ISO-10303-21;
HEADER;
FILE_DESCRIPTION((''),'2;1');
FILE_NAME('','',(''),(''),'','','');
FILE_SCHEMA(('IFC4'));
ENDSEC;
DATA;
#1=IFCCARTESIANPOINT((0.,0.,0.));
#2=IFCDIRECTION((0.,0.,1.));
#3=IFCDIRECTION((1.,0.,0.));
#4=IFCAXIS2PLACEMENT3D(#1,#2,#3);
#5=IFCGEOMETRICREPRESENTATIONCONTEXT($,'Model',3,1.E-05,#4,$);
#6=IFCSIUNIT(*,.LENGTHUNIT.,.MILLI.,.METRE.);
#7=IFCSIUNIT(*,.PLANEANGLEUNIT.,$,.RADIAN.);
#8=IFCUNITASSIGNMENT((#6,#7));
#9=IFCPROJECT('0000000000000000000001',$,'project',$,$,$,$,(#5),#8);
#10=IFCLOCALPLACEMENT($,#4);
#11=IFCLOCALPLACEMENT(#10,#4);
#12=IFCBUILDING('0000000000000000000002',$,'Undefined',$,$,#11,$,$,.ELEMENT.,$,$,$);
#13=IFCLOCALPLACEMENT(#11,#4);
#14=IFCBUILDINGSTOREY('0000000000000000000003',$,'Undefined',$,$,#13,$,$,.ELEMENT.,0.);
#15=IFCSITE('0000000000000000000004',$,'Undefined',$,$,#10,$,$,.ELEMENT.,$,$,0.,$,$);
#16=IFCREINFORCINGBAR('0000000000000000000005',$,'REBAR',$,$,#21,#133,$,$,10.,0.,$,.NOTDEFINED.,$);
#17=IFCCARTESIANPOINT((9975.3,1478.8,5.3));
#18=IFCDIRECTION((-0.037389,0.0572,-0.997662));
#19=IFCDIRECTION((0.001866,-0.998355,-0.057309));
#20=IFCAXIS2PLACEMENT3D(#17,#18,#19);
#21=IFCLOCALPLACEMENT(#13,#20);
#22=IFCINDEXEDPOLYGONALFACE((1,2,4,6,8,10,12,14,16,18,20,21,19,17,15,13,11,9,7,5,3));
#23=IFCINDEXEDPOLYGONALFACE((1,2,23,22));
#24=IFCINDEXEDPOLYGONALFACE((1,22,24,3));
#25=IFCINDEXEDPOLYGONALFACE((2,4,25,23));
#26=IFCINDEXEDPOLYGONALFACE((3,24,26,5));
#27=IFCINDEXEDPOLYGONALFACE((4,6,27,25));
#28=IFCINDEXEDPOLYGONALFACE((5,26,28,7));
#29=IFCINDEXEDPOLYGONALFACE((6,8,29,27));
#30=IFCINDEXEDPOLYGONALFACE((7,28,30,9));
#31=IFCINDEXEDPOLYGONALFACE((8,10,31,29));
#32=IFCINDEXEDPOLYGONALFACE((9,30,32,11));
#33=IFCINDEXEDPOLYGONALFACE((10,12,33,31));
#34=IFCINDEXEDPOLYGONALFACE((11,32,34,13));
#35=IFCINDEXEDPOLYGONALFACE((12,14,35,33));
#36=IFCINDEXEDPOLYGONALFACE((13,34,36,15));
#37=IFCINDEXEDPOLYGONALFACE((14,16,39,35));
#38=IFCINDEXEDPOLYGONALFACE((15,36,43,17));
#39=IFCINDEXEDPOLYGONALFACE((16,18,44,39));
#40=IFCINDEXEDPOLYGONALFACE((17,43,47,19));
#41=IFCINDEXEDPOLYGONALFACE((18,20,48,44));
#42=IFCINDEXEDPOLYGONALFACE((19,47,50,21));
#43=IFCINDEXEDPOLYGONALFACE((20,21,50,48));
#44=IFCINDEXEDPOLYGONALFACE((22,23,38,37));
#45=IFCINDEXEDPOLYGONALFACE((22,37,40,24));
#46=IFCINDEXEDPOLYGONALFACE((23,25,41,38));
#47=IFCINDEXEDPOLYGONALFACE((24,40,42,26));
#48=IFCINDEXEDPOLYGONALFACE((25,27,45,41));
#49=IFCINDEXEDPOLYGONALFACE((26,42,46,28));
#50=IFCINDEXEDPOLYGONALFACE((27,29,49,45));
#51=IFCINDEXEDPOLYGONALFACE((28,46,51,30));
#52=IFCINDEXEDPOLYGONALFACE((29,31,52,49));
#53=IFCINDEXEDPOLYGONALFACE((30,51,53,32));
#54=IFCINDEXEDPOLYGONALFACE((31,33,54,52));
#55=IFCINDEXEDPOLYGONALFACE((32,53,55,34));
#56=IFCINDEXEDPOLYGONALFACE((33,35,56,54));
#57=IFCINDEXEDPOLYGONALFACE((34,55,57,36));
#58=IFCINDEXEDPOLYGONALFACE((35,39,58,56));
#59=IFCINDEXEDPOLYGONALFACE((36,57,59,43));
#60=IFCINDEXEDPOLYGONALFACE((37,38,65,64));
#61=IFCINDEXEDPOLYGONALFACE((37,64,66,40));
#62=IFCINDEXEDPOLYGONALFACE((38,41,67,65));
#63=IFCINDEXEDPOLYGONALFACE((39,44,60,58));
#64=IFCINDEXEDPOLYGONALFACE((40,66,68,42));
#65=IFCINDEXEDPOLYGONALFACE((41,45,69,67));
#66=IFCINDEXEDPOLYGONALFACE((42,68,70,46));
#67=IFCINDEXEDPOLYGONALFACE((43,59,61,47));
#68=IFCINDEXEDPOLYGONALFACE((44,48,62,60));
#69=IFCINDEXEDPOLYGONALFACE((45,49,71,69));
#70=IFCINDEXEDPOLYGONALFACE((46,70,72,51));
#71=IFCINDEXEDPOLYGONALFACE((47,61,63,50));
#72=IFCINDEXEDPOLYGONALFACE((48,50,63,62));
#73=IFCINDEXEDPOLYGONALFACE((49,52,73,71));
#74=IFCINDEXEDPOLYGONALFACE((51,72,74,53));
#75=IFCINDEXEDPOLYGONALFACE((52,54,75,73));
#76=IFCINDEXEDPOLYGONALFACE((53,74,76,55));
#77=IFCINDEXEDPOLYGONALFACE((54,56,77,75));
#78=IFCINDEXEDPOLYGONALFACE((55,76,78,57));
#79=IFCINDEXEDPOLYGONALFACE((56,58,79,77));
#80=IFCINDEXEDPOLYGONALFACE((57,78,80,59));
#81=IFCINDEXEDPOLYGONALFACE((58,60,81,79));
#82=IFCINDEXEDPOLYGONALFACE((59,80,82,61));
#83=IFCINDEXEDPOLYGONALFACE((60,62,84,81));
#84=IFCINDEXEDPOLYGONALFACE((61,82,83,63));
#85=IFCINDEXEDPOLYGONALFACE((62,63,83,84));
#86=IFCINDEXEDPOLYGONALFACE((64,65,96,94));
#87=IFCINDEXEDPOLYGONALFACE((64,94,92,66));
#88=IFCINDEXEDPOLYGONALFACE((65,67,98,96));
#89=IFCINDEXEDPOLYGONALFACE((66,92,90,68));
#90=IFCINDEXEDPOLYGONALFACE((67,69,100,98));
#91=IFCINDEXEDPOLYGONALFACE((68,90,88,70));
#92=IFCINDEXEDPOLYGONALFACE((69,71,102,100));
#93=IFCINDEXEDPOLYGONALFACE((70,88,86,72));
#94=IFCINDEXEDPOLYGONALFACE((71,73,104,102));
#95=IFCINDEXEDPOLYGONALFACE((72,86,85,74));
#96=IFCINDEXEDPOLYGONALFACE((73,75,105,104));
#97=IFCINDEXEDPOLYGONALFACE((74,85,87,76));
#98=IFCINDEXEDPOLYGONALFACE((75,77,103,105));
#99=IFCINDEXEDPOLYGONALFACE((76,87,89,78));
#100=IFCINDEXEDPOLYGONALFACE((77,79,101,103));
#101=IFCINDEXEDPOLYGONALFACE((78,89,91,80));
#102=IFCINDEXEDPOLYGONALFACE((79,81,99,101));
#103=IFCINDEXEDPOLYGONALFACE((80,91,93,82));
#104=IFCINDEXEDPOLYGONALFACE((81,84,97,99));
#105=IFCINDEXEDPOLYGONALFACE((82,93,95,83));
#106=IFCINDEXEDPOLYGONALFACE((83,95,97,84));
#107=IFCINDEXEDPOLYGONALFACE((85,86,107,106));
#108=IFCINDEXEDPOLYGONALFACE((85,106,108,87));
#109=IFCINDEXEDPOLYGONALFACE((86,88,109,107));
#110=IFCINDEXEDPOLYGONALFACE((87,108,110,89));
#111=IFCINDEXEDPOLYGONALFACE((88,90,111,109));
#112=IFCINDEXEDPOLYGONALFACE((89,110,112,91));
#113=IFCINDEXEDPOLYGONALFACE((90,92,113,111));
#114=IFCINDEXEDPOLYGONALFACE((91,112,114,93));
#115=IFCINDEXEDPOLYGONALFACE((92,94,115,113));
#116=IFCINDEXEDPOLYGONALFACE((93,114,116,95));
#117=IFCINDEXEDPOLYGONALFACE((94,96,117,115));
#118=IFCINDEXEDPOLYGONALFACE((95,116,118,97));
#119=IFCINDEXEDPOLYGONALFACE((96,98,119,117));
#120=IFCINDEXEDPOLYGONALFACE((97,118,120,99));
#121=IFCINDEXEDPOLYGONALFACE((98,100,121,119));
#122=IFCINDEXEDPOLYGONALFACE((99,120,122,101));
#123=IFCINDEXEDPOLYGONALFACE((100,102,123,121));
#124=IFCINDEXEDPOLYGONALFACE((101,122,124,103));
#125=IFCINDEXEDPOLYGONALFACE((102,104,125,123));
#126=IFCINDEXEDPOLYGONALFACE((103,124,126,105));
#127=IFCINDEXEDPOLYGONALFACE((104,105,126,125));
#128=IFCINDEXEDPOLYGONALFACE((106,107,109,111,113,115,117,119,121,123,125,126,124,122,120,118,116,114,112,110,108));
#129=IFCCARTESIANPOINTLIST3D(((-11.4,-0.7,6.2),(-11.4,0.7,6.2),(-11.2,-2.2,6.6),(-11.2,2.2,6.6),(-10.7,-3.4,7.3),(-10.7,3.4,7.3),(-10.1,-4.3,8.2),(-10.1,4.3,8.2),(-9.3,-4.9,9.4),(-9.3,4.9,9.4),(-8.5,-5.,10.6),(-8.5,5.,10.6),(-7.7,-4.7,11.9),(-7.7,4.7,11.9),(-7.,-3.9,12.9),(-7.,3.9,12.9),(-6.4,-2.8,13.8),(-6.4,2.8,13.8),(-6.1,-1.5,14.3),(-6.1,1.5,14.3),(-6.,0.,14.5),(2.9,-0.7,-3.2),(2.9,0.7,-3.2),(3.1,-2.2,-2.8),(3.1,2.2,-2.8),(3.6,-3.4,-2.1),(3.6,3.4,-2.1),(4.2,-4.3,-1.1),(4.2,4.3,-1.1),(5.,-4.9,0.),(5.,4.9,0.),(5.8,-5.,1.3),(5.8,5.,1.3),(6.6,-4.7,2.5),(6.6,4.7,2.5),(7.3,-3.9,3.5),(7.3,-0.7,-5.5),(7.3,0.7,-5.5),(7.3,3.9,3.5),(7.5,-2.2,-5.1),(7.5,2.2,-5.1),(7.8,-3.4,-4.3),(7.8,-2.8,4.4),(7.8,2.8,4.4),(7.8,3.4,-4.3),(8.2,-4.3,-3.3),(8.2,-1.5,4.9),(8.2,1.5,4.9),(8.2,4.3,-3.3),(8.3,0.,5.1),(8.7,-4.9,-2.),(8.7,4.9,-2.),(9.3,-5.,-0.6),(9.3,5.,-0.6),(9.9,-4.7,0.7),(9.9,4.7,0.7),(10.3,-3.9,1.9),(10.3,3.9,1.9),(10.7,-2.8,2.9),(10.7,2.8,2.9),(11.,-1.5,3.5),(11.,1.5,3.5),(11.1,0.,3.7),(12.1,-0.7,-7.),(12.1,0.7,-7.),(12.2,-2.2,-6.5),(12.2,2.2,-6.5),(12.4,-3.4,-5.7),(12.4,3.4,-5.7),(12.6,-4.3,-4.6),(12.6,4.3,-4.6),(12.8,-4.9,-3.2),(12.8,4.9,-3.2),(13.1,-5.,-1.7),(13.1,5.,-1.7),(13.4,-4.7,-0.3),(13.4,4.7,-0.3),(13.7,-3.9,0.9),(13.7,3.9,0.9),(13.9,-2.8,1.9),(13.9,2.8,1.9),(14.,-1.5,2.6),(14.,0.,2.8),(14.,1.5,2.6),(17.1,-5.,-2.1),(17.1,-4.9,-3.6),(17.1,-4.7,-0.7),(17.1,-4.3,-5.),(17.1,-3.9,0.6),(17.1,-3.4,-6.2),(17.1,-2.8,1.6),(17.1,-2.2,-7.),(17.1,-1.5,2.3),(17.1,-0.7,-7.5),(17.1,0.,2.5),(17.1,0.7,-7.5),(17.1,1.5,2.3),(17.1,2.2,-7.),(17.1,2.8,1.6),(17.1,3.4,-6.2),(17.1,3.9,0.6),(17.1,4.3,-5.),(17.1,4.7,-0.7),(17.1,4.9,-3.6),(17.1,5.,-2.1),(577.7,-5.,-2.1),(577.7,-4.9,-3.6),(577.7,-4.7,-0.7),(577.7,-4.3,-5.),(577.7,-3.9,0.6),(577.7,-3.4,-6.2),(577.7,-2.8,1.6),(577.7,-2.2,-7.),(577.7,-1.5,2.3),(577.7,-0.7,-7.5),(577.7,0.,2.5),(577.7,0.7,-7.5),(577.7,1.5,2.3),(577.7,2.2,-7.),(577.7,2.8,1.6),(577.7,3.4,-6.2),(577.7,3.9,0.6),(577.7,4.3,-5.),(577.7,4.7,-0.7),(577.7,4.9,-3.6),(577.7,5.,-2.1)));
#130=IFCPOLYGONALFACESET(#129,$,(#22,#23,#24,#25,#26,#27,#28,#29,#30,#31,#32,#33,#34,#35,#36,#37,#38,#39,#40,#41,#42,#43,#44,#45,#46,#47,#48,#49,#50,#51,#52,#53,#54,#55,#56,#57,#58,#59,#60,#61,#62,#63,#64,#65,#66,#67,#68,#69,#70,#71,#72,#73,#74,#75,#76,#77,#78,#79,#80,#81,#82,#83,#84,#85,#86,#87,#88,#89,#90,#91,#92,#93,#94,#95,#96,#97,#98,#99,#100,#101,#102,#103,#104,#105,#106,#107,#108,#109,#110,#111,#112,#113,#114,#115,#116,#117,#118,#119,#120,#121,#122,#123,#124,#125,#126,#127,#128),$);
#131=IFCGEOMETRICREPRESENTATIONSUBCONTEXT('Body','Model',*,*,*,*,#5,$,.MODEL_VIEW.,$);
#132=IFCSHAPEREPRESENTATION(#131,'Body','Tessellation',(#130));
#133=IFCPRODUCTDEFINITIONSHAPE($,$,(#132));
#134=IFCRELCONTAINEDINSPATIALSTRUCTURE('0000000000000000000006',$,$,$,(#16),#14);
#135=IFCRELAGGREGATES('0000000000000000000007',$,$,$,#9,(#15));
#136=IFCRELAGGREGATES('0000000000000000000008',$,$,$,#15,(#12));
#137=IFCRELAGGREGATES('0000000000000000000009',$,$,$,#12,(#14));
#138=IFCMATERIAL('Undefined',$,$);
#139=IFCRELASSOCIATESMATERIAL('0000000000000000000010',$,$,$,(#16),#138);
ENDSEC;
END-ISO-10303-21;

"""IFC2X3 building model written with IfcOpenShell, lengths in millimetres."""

from ifc_helpers import new_model, entity, si_unit, frame, origin_with_axes, place, context, subcontext, project, spatial, source, transform, mapped, material, element, save


model = new_model("IFC2X3")

# Units and contexts
model_context = context("Model", 3, precision=1e-05, world=origin_with_axes())
body_context = subcontext(model_context, "Body", "Model", "MODEL_VIEW")
ifc_project = project(units=[si_unit("LENGTHUNIT", "METRE", prefix="MILLI"), si_unit("PLANEANGLEUNIT", "RADIAN")], contexts=[model_context])

# Site, building, storey
site_placement = place(None, origin_with_axes())
site = spatial("IfcSite", under=ifc_project, at=site_placement, Name="Undefined", CompositionType="ELEMENT", RefElevation=0.0)
building_placement = place(site_placement, origin_with_axes())
building = spatial("IfcBuilding", under=site, at=building_placement, Name="Undefined", CompositionType="ELEMENT")
storey_placement = place(building_placement, origin_with_axes())
storey = spatial("IfcBuildingStorey", under=building, at=storey_placement, Name="Undefined", CompositionType="ELEMENT", Elevation=0.0)

# Reinforcing bar
ifc_material_1 = material(Name="Undefined")
shared_shape_1 = source(origin_with_axes(), body_context, "Body", "AdvancedSweptSolid", [
    entity("IfcSweptDiskSolid", entity("IfcCompositeCurve", [entity("IfcCompositeCurveSegment", "CONTINUOUS", True, entity("IfcTrimmedCurve", entity("IfcLine", entity("IfcCartesianPoint", [0.0, 0.0, 0.0]), entity("IfcVector", entity("IfcDirection", [0.835483, 0.0, -0.549516]), 1.0)), [entity("IfcParameterValue", 0.0)], [entity("IfcParameterValue", 17.082101)], True, "PARAMETER")), entity("IfcCompositeCurveSegment", "CONTINUOUS", True, entity("IfcTrimmedCurve", entity("IfcCircle", entity("IfcAxis2Placement3D", entity("IfcCartesianPoint", [25.8, 0.0, 8.2]), entity("IfcDirection", [0.0, -1.0, 0.0]), entity("IfcDirection", [-0.549516, 0.0, -0.835483])), 21.0), [entity("IfcParameterValue", 0.0)], [entity("IfcParameterValue", 0.581785)], True, "PARAMETER")), entity("IfcCompositeCurveSegment", "DISCONTINUOUS", True, entity("IfcTrimmedCurve", entity("IfcLine", entity("IfcCartesianPoint", [25.8, 0.0, -12.8]), entity("IfcVector", entity("IfcDirection", [1.0, 0.0, 0.0]), 1.0)), [entity("IfcParameterValue", 0.0)], [entity("IfcParameterValue", 560.593055)], True, "PARAMETER"))], False), 5.0, None, 0.0, 578.3),
])
reinforcing_bar_1_placement = place(storey_placement, frame((9975.3, 1478.8, 5.3), z_axis=(-0.037389, 0.0572, -0.997662), x_axis=(0.001866, -0.998355, -0.057309)))
element("IfcReinforcingBar", 1, at=reinforcing_bar_1_placement, inside=storey, material=ifc_material_1, Name="REBAR", BarRole="NOTDEFINED", CrossSectionArea=0.0, NominalDiameter=10.0, context=body_context, shape_type="MappedRepresentation", body=[
    mapped(shared_shape_1, transform((-8.7, 0.0, 10.3))),
])

save(model, "model.ifc")
